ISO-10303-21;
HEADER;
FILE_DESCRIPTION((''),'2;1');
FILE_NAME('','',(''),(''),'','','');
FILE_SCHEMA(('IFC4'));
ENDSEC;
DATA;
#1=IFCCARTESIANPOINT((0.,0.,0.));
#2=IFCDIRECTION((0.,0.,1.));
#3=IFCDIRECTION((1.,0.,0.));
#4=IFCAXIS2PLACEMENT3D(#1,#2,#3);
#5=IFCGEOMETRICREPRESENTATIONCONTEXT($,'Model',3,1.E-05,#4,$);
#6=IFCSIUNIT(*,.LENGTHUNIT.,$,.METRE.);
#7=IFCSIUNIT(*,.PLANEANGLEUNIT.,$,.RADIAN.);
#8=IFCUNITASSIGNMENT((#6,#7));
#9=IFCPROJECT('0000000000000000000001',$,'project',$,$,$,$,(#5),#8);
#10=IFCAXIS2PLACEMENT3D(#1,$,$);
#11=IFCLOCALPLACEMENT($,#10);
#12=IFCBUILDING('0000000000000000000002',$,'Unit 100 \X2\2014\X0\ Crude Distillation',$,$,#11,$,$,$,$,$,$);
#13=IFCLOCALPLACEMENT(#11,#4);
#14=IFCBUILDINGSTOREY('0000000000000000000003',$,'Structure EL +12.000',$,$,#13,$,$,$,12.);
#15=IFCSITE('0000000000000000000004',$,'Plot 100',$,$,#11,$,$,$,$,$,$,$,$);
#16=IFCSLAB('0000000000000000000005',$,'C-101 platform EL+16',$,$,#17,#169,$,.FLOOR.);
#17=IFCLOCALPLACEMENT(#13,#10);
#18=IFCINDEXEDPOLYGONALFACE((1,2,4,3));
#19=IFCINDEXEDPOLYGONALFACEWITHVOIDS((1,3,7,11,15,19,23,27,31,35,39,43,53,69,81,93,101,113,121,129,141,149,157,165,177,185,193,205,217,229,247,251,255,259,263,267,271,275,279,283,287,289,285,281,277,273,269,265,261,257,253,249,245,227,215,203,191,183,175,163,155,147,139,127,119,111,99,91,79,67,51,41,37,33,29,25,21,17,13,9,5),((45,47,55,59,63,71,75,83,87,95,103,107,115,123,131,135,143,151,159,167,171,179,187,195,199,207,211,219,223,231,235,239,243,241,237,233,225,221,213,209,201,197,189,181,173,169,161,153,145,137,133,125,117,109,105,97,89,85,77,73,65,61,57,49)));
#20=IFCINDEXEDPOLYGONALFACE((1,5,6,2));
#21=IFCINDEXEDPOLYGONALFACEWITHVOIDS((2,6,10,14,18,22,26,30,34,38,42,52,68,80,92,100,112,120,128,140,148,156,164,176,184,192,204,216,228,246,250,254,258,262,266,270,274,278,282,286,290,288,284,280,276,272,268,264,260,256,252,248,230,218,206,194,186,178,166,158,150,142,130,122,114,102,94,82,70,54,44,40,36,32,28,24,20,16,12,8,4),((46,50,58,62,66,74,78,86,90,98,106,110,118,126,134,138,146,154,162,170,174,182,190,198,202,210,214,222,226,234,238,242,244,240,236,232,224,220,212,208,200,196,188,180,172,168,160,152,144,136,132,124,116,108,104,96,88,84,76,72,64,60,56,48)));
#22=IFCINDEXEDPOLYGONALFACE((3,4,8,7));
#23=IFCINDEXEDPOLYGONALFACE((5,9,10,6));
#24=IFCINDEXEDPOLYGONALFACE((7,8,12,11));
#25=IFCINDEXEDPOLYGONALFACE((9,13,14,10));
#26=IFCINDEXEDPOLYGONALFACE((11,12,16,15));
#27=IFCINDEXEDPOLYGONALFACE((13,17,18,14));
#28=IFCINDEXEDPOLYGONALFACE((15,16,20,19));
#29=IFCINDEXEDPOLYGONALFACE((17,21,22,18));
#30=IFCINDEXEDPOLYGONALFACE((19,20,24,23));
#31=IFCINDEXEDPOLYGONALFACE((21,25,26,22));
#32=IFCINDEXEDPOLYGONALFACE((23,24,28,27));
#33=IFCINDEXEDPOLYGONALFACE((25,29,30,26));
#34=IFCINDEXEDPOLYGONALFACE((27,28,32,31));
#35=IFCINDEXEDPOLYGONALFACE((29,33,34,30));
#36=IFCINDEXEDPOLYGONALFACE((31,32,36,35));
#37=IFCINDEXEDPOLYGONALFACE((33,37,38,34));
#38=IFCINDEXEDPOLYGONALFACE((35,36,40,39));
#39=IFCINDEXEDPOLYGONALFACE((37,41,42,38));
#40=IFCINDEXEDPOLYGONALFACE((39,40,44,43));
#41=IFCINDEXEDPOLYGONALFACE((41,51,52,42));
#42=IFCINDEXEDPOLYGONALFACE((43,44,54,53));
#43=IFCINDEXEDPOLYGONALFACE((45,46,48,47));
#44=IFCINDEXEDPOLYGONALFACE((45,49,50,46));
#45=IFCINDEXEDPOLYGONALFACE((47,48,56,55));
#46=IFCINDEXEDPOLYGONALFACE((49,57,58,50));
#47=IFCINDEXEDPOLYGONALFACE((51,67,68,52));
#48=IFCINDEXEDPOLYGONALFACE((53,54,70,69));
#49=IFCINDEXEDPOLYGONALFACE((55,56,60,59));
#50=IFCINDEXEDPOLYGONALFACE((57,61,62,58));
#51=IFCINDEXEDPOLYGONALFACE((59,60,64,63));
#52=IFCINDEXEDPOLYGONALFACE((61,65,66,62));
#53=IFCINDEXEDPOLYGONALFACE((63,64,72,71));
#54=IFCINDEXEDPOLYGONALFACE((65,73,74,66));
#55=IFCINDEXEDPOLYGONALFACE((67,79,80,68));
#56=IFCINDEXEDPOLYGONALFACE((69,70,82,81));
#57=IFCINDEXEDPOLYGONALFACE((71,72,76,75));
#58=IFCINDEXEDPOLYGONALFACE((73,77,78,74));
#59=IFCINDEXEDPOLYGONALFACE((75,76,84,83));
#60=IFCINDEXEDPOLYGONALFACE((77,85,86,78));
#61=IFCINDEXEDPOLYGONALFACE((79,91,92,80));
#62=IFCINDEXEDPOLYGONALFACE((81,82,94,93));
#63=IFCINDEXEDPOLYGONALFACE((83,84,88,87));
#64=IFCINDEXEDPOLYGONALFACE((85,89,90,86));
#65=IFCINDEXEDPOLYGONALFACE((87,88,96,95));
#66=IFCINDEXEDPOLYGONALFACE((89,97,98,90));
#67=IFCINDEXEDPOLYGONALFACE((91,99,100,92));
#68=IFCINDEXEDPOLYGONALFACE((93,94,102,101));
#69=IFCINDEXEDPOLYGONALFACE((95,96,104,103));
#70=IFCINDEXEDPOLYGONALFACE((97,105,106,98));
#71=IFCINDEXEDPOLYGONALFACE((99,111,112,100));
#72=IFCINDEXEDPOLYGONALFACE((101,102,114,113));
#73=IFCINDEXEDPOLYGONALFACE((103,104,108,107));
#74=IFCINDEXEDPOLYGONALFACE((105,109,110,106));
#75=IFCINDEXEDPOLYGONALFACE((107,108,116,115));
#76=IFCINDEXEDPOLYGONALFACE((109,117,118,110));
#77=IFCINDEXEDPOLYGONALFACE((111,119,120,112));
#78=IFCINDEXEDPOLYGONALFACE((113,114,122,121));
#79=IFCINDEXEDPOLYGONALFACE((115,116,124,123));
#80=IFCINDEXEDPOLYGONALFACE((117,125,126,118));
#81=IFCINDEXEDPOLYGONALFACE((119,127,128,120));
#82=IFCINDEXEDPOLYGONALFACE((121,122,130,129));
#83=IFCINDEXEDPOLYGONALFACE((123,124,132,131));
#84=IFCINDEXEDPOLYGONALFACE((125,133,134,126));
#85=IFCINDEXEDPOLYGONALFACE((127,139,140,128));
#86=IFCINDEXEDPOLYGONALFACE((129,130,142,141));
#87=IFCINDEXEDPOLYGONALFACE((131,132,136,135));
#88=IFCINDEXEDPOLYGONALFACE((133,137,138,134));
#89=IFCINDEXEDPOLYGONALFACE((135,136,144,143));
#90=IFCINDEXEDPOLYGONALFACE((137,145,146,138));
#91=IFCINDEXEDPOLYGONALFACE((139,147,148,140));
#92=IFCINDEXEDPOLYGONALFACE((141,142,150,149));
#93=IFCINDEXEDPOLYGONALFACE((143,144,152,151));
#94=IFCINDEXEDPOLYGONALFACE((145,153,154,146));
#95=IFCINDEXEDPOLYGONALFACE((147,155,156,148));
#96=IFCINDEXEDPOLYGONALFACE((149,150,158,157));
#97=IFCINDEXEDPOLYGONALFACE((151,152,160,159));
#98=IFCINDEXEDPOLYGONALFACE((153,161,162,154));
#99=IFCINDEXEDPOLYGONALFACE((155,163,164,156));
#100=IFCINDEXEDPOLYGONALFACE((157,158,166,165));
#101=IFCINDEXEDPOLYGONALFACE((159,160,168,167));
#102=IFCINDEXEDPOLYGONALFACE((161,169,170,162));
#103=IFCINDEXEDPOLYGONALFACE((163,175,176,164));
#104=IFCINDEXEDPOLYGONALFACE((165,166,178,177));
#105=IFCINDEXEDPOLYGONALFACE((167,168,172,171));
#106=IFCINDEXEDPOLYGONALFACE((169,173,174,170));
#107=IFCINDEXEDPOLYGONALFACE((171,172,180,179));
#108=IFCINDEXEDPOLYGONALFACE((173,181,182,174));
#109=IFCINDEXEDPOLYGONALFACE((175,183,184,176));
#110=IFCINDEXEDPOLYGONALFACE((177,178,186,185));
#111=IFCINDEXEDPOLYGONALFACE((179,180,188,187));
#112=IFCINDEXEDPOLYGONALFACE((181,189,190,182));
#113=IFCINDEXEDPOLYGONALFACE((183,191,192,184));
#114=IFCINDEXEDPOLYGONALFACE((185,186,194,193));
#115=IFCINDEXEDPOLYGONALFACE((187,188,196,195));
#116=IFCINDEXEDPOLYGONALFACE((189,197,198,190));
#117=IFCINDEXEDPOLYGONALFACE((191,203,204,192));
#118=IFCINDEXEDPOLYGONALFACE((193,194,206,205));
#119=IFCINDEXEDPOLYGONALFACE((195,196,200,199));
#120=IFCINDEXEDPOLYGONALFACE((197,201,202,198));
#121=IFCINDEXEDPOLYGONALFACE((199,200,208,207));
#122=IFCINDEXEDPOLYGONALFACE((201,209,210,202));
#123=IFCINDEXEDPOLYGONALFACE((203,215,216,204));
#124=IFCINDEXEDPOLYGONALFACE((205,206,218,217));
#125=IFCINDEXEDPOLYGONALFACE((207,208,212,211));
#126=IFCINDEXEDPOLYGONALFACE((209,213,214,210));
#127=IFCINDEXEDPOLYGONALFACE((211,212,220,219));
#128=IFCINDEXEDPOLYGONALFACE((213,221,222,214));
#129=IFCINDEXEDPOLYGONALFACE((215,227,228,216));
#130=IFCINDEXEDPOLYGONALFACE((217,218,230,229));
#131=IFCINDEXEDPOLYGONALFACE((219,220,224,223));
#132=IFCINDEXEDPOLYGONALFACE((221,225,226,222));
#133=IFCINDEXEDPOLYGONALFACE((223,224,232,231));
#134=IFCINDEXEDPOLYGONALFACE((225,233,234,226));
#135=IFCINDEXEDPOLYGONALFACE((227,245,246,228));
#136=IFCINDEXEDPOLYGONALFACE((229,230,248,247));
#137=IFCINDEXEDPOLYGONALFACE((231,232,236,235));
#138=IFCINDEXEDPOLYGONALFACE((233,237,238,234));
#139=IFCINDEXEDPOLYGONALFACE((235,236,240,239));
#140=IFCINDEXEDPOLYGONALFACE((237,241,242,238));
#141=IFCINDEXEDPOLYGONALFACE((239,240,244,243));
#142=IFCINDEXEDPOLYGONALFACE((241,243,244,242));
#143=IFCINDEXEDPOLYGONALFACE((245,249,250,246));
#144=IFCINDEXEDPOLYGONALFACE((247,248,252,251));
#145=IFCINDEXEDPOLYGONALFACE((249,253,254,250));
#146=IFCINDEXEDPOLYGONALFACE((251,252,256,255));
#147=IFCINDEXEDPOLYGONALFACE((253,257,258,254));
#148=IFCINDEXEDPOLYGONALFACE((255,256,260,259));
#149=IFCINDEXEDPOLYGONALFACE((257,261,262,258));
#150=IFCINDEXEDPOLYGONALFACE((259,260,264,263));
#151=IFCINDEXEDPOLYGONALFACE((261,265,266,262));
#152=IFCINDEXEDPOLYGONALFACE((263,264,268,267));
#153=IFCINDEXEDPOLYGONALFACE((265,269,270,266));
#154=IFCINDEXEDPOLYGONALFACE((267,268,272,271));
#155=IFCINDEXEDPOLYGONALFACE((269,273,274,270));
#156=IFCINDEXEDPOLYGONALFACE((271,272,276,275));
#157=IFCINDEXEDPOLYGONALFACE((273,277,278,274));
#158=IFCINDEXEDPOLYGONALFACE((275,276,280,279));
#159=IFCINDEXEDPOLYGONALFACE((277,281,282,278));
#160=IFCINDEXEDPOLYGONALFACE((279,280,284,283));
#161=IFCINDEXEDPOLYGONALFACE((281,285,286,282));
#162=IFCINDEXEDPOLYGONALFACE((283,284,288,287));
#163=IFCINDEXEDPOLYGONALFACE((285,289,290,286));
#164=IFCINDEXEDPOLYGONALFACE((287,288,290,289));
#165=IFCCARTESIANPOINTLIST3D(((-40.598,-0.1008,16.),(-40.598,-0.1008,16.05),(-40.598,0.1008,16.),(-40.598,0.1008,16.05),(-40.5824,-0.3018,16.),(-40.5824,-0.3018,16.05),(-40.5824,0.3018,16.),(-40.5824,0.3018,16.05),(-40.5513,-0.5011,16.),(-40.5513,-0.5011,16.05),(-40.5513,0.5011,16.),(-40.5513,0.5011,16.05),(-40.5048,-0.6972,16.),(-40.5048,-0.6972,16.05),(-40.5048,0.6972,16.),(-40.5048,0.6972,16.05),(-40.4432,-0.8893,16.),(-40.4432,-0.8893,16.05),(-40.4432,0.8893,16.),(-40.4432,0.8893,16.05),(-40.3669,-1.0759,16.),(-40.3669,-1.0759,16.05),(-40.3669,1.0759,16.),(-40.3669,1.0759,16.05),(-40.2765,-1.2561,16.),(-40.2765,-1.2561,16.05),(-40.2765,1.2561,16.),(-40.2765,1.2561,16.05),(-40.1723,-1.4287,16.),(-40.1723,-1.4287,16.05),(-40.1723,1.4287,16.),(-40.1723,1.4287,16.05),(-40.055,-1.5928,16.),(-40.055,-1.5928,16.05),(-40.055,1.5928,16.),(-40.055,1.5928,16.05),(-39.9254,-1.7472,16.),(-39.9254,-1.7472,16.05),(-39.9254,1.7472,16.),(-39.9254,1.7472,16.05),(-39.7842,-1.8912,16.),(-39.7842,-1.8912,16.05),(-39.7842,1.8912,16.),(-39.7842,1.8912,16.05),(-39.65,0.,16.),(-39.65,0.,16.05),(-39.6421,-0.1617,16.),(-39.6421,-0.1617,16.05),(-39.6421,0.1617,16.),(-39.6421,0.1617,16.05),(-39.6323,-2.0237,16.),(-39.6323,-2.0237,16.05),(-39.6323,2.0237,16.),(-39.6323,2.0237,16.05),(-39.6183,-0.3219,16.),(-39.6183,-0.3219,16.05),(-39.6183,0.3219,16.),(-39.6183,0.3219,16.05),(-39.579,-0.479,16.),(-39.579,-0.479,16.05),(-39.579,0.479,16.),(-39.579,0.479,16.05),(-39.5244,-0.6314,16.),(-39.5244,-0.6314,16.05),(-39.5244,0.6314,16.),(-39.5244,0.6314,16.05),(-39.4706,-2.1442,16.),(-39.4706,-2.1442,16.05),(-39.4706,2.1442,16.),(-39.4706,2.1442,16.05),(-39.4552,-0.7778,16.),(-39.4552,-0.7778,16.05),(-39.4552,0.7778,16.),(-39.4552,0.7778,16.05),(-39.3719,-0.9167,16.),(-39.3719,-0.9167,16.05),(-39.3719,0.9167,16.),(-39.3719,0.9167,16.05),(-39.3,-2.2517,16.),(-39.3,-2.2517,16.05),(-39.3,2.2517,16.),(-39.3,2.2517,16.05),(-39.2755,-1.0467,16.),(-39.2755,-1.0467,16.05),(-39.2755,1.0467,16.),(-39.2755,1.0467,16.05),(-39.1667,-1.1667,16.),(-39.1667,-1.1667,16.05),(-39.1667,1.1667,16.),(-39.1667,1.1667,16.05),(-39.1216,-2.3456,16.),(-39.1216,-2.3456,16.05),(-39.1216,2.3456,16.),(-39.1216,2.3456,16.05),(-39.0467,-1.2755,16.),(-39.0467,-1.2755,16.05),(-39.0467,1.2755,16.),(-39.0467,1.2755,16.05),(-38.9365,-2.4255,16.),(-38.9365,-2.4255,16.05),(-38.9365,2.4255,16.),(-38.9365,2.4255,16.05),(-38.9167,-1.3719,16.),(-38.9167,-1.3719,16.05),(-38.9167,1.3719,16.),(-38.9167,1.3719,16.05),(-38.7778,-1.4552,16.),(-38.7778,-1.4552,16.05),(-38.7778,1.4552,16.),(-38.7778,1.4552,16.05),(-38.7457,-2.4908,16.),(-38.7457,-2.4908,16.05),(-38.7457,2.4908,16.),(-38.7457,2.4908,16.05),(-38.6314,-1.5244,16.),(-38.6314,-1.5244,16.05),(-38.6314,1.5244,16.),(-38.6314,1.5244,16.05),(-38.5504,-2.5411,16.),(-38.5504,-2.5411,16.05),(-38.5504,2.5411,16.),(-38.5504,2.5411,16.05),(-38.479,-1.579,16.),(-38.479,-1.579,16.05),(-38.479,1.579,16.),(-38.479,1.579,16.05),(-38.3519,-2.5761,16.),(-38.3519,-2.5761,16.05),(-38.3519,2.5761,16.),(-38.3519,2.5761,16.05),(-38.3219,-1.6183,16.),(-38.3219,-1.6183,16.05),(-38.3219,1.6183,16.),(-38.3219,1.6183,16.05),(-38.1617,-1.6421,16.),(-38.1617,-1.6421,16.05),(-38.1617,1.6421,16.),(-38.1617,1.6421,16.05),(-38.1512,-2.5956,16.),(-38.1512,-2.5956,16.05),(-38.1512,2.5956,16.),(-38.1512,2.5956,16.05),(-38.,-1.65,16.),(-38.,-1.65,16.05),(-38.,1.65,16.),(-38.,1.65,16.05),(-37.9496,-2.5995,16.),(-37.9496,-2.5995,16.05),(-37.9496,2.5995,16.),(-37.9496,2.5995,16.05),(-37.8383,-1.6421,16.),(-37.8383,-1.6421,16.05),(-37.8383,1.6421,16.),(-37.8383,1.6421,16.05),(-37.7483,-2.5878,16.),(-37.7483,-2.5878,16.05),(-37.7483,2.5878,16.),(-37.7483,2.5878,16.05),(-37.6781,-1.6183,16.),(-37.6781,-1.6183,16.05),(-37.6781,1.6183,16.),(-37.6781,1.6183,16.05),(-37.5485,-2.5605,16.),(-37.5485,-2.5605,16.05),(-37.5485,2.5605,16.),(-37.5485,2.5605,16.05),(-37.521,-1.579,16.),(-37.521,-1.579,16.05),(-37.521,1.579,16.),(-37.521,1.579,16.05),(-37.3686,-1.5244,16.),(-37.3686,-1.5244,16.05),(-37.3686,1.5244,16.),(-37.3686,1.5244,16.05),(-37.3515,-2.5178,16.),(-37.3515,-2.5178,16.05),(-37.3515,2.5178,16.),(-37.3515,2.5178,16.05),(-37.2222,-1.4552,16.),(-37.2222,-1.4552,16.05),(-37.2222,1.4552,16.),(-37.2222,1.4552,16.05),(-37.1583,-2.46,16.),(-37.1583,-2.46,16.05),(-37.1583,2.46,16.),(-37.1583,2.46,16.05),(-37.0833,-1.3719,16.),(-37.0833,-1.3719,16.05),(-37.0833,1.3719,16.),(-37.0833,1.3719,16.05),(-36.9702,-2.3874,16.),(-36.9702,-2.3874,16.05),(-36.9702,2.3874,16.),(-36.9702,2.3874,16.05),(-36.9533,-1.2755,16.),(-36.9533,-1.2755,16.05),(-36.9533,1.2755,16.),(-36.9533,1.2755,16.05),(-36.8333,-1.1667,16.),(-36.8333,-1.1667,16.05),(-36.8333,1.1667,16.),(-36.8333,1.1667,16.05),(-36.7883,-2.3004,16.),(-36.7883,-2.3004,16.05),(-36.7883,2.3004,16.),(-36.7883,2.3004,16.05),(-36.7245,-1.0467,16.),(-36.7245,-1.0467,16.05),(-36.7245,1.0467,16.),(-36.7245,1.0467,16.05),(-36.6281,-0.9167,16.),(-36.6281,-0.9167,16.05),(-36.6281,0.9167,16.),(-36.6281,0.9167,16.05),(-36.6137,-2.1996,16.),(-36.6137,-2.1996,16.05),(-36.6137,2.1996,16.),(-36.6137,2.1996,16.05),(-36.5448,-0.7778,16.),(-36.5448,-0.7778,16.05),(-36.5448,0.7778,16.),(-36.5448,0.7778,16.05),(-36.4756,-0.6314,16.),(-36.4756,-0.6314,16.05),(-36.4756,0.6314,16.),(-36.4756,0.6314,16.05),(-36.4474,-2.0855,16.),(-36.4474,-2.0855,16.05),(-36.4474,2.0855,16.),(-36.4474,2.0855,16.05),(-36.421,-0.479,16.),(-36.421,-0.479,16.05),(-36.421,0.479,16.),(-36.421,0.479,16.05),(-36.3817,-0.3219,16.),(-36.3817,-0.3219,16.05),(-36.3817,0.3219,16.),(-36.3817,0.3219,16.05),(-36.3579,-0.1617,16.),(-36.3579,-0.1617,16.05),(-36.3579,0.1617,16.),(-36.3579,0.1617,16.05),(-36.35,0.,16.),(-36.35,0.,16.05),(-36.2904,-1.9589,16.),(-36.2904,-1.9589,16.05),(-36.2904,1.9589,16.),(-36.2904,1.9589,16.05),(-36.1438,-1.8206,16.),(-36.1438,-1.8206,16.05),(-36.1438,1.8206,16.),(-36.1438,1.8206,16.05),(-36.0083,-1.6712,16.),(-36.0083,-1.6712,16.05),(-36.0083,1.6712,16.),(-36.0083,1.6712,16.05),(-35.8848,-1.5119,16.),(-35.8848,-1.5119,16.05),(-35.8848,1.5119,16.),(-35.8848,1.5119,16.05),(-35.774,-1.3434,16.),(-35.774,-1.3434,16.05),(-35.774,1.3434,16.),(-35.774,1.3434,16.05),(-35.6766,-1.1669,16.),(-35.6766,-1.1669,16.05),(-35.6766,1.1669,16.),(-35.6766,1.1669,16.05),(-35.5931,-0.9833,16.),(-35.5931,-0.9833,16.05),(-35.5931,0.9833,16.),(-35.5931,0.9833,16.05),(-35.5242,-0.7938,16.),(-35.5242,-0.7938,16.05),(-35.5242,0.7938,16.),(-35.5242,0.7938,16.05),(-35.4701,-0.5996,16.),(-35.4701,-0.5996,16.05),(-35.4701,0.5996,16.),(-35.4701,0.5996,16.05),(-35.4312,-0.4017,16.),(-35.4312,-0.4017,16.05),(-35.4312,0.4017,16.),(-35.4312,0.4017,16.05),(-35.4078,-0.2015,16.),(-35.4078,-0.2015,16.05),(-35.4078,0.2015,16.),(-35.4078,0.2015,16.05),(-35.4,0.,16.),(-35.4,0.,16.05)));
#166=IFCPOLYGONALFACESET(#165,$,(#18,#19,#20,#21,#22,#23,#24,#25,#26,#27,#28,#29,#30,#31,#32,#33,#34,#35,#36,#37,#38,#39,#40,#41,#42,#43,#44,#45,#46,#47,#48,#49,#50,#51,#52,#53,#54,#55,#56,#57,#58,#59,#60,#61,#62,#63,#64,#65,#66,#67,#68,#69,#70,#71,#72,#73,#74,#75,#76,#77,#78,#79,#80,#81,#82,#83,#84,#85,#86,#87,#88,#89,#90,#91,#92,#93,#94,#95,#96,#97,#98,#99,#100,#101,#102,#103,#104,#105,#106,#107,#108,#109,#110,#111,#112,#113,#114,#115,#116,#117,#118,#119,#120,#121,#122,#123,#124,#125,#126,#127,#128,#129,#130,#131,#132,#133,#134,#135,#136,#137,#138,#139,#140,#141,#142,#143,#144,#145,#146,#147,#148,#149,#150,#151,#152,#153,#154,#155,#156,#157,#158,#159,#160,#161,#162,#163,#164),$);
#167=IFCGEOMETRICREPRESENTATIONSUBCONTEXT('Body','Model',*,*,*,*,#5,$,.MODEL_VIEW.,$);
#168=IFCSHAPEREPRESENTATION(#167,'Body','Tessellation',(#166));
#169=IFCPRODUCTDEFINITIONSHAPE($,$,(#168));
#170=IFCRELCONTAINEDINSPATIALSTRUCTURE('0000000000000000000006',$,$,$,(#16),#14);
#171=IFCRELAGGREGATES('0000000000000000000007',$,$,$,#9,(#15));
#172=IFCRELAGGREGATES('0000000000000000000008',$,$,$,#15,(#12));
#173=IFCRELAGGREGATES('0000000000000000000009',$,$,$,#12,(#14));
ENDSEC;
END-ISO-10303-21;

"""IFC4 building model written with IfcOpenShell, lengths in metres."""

from ifc_helpers import new_model, si_unit, frame, origin, origin_with_axes, origin_2d, place, context, subcontext, project, spatial, hollow_circle, extrude, element, save


model = new_model("IFC4")

# Units and contexts
model_context = context("Model", 3, precision=1e-05, world=origin_with_axes())
body_context = subcontext(model_context, "Body", "Model", "MODEL_VIEW")
ifc_project = project(units=[si_unit("LENGTHUNIT", "METRE"), si_unit("PLANEANGLEUNIT", "RADIAN")], contexts=[model_context])

# Site, building, storey
placement = place(None, origin())
site = spatial("IfcSite", under=ifc_project, at=placement, Name="Plot 100")
building = spatial("IfcBuilding", under=site, at=placement, Name="Unit 100 — Crude Distillation")
storey_placement = place(placement, origin_with_axes())
storey = spatial("IfcBuildingStorey", under=building, at=storey_placement, Name="Structure EL +12.000", Elevation=12.0)

# Slab
slab_placement = place(storey_placement, origin_with_axes())
element("IfcSlab", 1, at=slab_placement, inside=storey, Name="C-101 platform EL+16", PredefinedType="FLOOR", context=body_context, shape_type="SweptSolid", body=[
    extrude(hollow_circle(Radius=2.6, WallThickness=0.95, at=origin_2d()), frame((-38.0, 0.0, 16.0), z_axis=(0.0, 0.0, 1.0), x_axis=(1.0, 0.0, 0.0)), (0.0, 0.0, 1.0), 0.05),
])

save(model, "model.ifc")
